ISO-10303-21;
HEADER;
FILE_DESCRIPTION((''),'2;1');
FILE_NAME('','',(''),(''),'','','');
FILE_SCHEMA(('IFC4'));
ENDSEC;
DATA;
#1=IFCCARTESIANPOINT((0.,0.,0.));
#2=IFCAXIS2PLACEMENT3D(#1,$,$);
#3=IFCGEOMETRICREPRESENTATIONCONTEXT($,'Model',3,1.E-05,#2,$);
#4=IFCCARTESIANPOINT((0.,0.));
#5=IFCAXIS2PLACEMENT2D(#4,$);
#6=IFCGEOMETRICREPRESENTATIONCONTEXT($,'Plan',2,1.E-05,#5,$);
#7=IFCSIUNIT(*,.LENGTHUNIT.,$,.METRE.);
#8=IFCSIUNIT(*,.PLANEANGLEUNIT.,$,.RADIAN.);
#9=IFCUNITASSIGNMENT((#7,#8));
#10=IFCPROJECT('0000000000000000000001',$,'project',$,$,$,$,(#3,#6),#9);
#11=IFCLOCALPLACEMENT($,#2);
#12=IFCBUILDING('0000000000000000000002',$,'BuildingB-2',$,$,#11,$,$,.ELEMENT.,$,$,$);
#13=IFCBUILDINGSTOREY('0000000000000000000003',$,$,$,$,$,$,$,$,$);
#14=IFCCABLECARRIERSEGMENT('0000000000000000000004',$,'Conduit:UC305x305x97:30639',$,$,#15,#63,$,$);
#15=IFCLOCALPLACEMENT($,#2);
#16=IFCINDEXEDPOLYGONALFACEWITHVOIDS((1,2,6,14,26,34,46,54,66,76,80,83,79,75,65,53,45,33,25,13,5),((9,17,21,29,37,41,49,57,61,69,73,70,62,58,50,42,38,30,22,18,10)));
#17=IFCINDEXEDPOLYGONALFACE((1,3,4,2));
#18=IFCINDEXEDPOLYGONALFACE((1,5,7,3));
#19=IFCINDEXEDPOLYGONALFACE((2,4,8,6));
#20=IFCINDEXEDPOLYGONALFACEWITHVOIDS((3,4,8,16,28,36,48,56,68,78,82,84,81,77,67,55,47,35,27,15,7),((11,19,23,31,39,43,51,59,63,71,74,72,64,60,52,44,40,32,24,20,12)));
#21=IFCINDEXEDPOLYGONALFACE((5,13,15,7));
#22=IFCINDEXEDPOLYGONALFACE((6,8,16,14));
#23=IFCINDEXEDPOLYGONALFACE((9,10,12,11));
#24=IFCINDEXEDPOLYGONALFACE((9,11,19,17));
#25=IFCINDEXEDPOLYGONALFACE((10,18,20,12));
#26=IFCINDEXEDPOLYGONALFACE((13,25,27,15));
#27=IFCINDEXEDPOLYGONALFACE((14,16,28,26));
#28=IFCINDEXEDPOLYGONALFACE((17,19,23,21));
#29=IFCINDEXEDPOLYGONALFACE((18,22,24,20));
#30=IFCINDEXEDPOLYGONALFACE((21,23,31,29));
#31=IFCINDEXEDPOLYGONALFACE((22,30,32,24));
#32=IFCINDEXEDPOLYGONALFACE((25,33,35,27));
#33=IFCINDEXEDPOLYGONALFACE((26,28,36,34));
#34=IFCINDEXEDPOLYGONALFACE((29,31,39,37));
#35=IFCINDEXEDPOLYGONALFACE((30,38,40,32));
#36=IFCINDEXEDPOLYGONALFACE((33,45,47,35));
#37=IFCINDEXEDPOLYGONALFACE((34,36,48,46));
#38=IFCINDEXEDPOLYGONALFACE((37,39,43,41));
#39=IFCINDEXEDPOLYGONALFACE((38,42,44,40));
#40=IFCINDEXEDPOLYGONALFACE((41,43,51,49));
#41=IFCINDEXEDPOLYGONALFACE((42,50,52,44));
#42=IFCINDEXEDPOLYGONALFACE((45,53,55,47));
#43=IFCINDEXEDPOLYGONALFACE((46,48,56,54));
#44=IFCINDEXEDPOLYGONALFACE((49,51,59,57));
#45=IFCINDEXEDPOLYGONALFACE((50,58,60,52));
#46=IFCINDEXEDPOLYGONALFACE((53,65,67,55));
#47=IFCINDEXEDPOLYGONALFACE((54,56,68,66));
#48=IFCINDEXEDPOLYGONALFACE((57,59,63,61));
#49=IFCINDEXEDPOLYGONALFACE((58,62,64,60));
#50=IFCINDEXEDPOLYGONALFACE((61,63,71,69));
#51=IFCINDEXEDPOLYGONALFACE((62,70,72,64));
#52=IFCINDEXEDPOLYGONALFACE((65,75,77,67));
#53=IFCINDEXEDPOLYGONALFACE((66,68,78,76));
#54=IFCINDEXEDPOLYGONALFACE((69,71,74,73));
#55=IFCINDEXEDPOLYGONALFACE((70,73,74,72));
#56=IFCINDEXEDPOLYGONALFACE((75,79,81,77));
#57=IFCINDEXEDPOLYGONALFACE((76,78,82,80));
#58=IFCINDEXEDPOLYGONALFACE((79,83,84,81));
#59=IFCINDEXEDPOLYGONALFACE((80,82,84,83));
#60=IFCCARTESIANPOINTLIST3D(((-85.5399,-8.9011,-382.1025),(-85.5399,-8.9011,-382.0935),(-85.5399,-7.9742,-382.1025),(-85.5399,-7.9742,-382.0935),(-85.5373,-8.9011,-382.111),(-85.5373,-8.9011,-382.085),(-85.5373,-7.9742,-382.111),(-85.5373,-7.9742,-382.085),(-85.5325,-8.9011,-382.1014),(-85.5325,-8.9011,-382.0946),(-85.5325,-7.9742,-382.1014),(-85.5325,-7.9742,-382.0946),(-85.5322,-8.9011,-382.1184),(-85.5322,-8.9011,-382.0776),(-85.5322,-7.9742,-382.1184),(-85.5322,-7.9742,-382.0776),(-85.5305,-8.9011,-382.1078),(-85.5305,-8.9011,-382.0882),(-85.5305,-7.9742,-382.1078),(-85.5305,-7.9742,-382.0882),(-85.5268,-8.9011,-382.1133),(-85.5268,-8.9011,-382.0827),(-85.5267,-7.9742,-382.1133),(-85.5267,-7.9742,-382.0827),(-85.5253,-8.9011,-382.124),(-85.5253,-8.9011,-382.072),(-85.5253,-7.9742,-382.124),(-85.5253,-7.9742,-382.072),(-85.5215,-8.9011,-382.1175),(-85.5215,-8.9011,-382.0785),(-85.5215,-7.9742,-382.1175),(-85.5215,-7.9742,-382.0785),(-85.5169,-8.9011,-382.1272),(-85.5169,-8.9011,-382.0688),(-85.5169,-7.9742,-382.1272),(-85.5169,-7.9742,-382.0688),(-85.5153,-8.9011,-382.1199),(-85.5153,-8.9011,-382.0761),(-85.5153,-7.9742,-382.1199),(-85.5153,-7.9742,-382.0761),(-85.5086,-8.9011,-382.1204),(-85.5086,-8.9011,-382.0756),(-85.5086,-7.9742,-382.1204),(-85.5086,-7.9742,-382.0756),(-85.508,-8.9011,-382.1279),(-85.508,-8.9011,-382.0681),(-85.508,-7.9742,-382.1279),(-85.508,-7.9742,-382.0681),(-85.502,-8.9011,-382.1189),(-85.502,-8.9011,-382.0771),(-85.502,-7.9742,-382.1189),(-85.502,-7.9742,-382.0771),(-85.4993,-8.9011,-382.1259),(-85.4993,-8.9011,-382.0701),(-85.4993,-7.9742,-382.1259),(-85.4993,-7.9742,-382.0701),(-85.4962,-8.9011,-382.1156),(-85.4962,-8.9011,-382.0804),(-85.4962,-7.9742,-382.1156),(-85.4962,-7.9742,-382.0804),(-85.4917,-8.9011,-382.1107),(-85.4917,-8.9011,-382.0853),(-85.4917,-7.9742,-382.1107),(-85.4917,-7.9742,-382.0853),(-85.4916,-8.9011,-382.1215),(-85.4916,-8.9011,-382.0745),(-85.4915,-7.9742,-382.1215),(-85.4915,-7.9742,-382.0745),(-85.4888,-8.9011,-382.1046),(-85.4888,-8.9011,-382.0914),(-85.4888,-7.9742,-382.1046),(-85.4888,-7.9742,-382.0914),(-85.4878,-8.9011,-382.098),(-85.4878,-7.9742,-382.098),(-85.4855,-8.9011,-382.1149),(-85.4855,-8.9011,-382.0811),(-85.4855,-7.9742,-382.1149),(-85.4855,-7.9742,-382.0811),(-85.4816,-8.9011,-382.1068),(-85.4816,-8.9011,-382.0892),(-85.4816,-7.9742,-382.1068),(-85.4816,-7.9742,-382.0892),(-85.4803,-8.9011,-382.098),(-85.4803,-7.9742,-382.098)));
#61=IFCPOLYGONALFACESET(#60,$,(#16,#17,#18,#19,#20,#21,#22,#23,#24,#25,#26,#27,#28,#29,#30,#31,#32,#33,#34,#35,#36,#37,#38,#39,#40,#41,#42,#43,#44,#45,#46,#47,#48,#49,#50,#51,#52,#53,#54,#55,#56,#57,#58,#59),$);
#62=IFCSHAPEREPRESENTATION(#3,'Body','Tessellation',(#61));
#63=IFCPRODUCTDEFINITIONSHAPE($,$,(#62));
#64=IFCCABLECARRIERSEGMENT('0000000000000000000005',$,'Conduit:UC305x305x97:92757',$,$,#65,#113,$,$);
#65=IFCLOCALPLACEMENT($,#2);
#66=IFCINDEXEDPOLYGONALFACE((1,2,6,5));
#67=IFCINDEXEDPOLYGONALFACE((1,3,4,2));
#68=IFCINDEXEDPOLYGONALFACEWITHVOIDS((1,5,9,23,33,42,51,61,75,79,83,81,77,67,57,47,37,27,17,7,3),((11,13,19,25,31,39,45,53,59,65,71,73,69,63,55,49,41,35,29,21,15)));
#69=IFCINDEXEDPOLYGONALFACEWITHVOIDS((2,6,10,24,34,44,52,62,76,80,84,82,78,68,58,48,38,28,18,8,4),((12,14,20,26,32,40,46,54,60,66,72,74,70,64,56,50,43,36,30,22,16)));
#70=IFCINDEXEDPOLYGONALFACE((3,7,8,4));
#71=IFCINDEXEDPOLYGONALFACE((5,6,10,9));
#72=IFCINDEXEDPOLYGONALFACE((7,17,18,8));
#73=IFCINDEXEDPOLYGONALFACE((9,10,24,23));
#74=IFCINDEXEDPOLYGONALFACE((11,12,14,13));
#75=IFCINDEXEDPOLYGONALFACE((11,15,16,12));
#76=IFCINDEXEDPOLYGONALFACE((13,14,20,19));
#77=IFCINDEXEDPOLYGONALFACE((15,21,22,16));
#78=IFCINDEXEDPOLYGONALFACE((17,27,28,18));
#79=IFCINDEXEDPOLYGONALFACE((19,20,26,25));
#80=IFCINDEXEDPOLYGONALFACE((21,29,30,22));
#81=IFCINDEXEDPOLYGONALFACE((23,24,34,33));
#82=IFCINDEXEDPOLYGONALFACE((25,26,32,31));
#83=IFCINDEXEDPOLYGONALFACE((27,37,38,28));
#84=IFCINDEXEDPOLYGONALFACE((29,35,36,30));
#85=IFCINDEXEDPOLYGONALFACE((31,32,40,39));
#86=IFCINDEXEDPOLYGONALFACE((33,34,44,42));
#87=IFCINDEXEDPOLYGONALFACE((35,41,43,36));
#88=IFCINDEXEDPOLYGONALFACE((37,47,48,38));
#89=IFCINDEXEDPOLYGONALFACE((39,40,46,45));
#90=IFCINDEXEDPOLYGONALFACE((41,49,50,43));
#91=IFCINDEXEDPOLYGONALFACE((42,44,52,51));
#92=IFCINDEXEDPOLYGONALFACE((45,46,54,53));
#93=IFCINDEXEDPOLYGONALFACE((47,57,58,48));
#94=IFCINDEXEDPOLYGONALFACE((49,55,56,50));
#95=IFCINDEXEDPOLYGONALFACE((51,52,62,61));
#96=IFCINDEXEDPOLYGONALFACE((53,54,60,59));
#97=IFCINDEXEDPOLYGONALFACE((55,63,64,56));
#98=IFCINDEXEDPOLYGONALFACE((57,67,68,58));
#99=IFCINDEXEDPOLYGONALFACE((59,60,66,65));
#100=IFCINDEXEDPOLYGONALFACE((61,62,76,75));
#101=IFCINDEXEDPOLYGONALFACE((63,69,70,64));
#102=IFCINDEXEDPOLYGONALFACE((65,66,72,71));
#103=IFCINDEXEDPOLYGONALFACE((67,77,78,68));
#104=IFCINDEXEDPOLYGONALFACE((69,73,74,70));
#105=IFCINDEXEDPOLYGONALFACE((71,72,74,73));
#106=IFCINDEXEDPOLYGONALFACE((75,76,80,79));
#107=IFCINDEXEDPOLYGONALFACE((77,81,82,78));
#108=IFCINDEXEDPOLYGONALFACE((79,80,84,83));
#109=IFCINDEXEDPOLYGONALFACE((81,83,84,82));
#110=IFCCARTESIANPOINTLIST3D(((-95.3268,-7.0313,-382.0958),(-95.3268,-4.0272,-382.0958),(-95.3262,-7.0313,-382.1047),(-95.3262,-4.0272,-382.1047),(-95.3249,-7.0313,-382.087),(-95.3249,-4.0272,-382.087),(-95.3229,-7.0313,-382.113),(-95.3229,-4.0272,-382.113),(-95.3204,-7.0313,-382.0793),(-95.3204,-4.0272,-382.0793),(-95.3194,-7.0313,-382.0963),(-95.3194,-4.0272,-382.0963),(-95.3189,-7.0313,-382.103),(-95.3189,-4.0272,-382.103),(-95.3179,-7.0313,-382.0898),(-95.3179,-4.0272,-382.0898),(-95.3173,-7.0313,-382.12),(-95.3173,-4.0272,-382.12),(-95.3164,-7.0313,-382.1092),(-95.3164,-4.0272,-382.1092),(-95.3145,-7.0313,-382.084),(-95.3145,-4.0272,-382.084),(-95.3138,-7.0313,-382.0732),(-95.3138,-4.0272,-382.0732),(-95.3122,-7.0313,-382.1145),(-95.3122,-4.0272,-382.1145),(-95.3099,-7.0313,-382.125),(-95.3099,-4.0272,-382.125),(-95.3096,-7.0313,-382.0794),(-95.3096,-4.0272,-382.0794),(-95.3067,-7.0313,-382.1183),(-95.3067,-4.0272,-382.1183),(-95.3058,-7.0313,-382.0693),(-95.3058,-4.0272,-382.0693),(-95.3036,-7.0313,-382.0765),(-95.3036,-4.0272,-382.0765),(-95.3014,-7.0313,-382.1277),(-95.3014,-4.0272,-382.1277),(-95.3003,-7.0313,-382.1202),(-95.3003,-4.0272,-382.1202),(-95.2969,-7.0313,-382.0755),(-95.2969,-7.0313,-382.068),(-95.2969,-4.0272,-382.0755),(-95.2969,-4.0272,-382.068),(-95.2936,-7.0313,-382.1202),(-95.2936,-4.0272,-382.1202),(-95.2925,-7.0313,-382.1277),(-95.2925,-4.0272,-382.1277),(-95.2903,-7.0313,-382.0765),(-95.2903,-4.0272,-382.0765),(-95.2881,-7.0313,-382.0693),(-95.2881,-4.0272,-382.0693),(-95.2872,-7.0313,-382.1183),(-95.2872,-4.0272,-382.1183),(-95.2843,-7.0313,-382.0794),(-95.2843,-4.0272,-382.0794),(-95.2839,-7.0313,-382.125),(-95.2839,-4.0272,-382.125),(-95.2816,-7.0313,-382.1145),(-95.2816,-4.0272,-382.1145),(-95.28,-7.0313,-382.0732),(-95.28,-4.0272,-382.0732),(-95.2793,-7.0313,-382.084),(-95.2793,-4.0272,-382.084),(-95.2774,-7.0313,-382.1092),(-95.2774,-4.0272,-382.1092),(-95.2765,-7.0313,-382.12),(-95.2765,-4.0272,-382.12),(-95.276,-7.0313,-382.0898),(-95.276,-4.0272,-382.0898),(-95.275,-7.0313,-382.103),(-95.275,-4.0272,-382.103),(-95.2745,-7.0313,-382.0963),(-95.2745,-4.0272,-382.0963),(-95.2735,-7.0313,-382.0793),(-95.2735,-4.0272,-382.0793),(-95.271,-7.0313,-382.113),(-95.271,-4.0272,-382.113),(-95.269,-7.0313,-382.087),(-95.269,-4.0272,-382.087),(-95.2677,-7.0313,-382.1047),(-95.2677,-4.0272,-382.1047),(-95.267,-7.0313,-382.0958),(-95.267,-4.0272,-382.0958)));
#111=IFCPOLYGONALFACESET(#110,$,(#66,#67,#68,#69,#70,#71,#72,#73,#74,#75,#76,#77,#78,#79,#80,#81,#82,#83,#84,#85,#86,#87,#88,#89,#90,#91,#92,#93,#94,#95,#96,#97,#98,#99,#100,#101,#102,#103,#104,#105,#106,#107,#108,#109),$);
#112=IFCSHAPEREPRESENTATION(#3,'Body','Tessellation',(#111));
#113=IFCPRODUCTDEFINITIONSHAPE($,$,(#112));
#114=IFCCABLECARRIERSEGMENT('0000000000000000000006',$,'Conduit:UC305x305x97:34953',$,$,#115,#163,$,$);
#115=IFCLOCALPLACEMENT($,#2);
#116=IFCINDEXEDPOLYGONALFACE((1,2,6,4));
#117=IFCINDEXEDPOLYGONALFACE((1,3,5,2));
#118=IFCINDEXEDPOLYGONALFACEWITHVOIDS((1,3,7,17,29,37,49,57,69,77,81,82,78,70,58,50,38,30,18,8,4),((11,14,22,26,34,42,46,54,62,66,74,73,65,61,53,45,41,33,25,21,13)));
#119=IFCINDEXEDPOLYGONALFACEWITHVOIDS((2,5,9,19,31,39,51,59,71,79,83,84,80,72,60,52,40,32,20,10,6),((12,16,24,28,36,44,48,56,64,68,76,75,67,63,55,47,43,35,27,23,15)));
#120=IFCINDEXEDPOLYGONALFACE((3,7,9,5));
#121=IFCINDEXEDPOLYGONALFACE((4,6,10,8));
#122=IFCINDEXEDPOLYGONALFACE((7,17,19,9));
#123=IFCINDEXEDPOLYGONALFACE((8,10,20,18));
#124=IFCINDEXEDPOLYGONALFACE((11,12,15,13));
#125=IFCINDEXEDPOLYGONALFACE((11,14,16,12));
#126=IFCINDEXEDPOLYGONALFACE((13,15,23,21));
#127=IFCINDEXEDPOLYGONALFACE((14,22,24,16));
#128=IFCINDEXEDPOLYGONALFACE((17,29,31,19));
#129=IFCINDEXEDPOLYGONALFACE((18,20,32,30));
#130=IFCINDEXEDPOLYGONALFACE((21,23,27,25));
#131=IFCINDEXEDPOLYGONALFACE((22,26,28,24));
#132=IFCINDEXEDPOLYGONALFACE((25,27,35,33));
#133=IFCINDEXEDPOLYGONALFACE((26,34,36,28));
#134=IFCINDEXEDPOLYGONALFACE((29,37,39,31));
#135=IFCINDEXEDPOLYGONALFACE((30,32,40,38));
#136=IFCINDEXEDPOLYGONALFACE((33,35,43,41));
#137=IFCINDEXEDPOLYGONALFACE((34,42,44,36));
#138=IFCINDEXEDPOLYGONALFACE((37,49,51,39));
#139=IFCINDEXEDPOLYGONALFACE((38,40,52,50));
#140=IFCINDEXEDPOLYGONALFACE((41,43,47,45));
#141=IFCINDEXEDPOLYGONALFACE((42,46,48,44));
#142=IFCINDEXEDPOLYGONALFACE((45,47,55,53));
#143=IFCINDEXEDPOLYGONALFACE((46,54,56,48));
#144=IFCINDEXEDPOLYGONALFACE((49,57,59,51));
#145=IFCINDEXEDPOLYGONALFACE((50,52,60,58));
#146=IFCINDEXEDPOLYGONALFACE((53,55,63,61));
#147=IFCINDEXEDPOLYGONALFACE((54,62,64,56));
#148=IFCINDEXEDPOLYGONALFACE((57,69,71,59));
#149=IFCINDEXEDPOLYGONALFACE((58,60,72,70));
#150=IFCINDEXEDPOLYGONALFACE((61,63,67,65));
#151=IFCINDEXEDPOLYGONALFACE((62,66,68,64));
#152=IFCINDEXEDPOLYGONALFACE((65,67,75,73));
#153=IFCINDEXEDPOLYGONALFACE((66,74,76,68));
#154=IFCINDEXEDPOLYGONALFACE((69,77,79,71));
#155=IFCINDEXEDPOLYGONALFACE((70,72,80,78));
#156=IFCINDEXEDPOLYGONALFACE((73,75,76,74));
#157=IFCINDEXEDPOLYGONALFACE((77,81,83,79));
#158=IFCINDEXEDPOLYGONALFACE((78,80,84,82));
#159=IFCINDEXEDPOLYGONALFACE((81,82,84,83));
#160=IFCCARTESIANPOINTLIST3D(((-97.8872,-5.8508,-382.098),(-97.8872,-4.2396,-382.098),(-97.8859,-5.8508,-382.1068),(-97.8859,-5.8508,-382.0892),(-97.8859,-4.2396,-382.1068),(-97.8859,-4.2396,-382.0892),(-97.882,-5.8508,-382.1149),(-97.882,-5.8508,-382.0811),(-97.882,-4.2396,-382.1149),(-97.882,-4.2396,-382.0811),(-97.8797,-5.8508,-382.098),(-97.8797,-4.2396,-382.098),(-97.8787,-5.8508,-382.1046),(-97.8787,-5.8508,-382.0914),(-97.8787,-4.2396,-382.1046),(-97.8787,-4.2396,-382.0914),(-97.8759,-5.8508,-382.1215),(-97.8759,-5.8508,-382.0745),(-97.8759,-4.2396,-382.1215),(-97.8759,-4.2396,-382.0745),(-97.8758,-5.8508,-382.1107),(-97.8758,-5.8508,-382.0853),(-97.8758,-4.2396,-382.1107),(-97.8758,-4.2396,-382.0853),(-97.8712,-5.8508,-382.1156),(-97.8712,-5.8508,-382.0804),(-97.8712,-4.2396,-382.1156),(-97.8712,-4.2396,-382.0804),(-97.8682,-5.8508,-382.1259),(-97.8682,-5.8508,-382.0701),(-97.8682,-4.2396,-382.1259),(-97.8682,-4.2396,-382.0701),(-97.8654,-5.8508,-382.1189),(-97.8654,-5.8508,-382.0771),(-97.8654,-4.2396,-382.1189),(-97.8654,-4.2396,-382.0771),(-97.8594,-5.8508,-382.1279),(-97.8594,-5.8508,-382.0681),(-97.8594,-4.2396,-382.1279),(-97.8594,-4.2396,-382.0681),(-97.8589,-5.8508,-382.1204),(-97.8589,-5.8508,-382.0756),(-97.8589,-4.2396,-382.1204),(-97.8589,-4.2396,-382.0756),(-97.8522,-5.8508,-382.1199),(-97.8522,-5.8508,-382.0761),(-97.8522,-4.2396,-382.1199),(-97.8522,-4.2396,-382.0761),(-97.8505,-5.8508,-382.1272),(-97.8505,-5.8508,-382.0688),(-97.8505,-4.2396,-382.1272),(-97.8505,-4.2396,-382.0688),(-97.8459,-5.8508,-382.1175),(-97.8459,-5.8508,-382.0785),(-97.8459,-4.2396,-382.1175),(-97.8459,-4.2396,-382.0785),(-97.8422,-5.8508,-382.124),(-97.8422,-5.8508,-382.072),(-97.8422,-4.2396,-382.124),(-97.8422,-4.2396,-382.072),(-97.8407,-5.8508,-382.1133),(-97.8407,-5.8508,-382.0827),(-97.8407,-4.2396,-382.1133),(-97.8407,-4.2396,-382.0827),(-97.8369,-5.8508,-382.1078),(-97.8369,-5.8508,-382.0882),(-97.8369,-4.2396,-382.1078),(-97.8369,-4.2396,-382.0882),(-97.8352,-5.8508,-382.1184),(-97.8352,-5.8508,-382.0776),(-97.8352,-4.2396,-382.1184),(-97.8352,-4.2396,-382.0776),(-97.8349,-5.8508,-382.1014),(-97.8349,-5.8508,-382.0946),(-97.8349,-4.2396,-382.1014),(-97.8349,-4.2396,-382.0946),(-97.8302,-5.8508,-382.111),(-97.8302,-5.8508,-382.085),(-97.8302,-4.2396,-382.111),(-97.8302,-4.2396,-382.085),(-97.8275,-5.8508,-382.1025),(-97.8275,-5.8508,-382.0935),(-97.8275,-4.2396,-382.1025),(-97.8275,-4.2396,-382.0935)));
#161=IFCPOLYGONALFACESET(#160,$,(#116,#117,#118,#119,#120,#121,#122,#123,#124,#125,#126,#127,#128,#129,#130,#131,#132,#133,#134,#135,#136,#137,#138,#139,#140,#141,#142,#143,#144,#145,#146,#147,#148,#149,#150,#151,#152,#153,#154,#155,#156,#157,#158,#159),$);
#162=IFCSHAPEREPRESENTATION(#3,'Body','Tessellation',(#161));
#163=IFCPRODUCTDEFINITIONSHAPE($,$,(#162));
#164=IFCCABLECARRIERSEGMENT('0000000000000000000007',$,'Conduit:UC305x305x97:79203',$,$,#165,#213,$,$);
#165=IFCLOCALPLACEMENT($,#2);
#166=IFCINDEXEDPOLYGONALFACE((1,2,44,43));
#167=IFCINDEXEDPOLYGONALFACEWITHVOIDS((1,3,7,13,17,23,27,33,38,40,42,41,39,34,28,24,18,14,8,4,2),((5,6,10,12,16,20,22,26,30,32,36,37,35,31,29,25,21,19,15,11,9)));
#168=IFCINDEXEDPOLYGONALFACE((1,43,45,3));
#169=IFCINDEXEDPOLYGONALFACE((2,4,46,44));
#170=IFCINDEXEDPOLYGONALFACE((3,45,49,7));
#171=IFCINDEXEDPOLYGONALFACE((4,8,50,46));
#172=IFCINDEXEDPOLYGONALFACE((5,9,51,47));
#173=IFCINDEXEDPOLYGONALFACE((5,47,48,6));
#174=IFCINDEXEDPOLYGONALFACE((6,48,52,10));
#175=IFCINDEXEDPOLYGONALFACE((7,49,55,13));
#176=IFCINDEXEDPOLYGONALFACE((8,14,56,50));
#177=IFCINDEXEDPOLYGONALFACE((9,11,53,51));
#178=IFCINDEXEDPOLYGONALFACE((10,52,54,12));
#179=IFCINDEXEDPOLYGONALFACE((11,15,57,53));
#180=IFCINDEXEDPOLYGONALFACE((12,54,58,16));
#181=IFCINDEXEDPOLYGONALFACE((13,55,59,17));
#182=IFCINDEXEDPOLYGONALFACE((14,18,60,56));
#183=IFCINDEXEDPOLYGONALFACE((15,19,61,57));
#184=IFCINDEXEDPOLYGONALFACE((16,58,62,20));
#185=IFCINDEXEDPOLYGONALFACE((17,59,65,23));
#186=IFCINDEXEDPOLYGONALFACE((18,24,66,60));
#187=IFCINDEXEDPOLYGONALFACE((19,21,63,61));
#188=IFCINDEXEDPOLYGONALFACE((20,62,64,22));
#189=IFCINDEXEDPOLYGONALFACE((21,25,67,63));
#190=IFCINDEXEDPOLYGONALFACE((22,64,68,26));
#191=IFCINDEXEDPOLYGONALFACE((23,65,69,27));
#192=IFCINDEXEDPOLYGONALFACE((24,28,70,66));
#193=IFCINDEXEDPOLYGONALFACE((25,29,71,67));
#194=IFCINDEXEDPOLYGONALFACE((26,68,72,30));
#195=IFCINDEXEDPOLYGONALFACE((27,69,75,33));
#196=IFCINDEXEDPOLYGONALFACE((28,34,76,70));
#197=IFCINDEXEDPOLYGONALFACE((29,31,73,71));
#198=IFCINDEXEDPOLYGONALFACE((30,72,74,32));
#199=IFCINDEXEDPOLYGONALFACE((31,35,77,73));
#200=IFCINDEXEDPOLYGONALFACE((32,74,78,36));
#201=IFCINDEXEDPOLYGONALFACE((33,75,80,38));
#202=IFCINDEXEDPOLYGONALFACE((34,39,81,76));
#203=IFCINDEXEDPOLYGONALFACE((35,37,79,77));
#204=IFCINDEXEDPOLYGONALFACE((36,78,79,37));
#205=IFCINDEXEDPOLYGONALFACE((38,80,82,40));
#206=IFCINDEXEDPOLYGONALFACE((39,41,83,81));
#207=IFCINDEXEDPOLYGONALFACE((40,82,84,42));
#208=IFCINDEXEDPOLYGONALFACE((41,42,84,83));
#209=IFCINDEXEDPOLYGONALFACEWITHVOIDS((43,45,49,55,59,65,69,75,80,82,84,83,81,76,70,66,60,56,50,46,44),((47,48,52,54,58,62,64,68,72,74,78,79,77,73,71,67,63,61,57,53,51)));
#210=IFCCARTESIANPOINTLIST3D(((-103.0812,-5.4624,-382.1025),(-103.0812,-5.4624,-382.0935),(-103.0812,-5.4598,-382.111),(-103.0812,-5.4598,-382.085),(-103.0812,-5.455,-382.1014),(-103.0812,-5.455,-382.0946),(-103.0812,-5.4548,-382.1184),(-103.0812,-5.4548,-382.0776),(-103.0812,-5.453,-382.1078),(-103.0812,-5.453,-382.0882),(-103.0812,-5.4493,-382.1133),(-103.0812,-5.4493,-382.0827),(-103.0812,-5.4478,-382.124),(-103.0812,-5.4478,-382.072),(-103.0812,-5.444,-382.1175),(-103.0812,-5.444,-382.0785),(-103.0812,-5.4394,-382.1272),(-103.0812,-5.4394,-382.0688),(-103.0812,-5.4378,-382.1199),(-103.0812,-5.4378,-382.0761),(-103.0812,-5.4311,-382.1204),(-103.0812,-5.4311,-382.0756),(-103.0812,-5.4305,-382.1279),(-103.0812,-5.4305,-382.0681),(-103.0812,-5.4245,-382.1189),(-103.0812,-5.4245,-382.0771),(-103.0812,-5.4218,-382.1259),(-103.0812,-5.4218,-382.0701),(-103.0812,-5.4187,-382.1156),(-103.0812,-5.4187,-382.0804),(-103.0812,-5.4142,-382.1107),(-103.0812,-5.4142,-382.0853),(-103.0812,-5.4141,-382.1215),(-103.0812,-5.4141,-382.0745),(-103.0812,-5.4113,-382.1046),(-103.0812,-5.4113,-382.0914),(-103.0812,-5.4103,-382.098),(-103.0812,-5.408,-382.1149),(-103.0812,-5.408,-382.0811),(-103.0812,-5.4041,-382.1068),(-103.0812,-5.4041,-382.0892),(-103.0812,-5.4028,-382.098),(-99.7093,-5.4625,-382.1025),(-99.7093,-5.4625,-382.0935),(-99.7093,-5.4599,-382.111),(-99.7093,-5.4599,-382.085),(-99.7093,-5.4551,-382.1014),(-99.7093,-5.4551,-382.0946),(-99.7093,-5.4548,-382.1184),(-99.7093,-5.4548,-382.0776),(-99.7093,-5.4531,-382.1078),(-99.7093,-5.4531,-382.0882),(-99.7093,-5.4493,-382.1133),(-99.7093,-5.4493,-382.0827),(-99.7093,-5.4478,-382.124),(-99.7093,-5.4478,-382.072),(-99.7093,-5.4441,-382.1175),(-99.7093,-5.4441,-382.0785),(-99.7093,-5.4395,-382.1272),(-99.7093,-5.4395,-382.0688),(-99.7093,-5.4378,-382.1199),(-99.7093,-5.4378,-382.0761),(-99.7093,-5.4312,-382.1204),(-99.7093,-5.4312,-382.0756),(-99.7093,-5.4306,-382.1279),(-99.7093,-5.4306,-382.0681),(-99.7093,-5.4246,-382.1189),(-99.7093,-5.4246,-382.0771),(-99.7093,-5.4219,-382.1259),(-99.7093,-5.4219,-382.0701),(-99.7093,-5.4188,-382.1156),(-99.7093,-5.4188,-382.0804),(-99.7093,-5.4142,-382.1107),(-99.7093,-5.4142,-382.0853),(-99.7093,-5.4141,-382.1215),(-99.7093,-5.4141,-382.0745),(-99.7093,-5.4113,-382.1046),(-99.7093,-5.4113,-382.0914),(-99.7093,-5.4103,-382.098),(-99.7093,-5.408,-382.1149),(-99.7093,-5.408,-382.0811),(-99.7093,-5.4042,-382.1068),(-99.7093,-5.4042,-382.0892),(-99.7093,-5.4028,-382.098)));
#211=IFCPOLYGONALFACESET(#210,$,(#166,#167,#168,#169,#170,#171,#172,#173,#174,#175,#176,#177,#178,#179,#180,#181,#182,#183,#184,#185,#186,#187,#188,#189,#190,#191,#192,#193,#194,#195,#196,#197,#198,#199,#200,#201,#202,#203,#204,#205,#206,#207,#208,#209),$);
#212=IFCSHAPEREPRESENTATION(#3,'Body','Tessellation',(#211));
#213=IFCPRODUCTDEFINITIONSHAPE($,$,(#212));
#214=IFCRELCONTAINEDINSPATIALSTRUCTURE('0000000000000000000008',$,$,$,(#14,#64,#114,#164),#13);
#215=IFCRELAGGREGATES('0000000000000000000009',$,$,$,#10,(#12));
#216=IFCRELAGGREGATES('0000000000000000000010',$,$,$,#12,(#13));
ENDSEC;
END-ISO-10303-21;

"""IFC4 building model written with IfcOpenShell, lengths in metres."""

from ifc_helpers import new_model, entity, si_unit, origin, origin_2d, place, context, project, spatial, element, save


model = new_model("IFC4")

# Units and contexts
model_context = context("Model", 3, precision=1e-05, world=origin())
plan_context = context("Plan", 2, precision=1e-05, world=origin_2d())
ifc_project = project(units=[si_unit("LENGTHUNIT", "METRE"), si_unit("PLANEANGLEUNIT", "RADIAN")], contexts=[model_context, plan_context])

# Building, storey
building_placement = place(None, origin())
building = spatial("IfcBuilding", under=ifc_project, at=building_placement, Name="BuildingB-2", CompositionType="ELEMENT")
storey = spatial("IfcBuildingStorey", under=building)

# Cable carrier segments
element("IfcCableCarrierSegment", 1, inside=storey, Name="Conduit:UC305x305x97:30639", context=model_context, shape_type="AdvancedSweptSolid", body=[
    entity("IfcSweptDiskSolid", entity("IfcCompositeCurve", [entity("IfcCompositeCurveSegment", "CONTINUOUS", False, entity("IfcPolyline", [entity("IfcCartesianPoint", [85.5103, 7.9742, 382.098]), entity("IfcCartesianPoint", [85.5103, 8.9011, 382.098])]))], False), 0.03, 0.0225),
])
element("IfcCableCarrierSegment", 2, inside=storey, Name="Conduit:UC305x305x97:92757", context=model_context, shape_type="AdvancedSweptSolid", body=[
    entity("IfcSweptDiskSolid", entity("IfcCompositeCurve", [entity("IfcCompositeCurveSegment", "CONTINUOUS", False, entity("IfcPolyline", [entity("IfcCartesianPoint", [95.2969, 4.0272, 382.098]), entity("IfcCartesianPoint", [95.2969, 7.0313, 382.098])]))], False), 0.03, 0.0225),
])
element("IfcCableCarrierSegment", 3, inside=storey, Name="Conduit:UC305x305x97:34953", context=model_context, shape_type="AdvancedSweptSolid", body=[
    entity("IfcSweptDiskSolid", entity("IfcCompositeCurve", [entity("IfcCompositeCurveSegment", "CONTINUOUS", False, entity("IfcPolyline", [entity("IfcCartesianPoint", [97.8572, 5.8508, 382.098]), entity("IfcCartesianPoint", [97.8572, 4.2396, 382.098])]))], False), 0.03, 0.0225),
])
element("IfcCableCarrierSegment", 4, inside=storey, Name="Conduit:UC305x305x97:79203", context=model_context, shape_type="AdvancedSweptSolid", body=[
    entity("IfcSweptDiskSolid", entity("IfcCompositeCurve", [entity("IfcCompositeCurveSegment", "CONTINUOUS", False, entity("IfcPolyline", [entity("IfcCartesianPoint", [99.7093, 5.4328, 382.098]), entity("IfcCartesianPoint", [103.0812, 5.4328, 382.098])]))], False), 0.03, 0.0225),
])

save(model, "model.ifc")
